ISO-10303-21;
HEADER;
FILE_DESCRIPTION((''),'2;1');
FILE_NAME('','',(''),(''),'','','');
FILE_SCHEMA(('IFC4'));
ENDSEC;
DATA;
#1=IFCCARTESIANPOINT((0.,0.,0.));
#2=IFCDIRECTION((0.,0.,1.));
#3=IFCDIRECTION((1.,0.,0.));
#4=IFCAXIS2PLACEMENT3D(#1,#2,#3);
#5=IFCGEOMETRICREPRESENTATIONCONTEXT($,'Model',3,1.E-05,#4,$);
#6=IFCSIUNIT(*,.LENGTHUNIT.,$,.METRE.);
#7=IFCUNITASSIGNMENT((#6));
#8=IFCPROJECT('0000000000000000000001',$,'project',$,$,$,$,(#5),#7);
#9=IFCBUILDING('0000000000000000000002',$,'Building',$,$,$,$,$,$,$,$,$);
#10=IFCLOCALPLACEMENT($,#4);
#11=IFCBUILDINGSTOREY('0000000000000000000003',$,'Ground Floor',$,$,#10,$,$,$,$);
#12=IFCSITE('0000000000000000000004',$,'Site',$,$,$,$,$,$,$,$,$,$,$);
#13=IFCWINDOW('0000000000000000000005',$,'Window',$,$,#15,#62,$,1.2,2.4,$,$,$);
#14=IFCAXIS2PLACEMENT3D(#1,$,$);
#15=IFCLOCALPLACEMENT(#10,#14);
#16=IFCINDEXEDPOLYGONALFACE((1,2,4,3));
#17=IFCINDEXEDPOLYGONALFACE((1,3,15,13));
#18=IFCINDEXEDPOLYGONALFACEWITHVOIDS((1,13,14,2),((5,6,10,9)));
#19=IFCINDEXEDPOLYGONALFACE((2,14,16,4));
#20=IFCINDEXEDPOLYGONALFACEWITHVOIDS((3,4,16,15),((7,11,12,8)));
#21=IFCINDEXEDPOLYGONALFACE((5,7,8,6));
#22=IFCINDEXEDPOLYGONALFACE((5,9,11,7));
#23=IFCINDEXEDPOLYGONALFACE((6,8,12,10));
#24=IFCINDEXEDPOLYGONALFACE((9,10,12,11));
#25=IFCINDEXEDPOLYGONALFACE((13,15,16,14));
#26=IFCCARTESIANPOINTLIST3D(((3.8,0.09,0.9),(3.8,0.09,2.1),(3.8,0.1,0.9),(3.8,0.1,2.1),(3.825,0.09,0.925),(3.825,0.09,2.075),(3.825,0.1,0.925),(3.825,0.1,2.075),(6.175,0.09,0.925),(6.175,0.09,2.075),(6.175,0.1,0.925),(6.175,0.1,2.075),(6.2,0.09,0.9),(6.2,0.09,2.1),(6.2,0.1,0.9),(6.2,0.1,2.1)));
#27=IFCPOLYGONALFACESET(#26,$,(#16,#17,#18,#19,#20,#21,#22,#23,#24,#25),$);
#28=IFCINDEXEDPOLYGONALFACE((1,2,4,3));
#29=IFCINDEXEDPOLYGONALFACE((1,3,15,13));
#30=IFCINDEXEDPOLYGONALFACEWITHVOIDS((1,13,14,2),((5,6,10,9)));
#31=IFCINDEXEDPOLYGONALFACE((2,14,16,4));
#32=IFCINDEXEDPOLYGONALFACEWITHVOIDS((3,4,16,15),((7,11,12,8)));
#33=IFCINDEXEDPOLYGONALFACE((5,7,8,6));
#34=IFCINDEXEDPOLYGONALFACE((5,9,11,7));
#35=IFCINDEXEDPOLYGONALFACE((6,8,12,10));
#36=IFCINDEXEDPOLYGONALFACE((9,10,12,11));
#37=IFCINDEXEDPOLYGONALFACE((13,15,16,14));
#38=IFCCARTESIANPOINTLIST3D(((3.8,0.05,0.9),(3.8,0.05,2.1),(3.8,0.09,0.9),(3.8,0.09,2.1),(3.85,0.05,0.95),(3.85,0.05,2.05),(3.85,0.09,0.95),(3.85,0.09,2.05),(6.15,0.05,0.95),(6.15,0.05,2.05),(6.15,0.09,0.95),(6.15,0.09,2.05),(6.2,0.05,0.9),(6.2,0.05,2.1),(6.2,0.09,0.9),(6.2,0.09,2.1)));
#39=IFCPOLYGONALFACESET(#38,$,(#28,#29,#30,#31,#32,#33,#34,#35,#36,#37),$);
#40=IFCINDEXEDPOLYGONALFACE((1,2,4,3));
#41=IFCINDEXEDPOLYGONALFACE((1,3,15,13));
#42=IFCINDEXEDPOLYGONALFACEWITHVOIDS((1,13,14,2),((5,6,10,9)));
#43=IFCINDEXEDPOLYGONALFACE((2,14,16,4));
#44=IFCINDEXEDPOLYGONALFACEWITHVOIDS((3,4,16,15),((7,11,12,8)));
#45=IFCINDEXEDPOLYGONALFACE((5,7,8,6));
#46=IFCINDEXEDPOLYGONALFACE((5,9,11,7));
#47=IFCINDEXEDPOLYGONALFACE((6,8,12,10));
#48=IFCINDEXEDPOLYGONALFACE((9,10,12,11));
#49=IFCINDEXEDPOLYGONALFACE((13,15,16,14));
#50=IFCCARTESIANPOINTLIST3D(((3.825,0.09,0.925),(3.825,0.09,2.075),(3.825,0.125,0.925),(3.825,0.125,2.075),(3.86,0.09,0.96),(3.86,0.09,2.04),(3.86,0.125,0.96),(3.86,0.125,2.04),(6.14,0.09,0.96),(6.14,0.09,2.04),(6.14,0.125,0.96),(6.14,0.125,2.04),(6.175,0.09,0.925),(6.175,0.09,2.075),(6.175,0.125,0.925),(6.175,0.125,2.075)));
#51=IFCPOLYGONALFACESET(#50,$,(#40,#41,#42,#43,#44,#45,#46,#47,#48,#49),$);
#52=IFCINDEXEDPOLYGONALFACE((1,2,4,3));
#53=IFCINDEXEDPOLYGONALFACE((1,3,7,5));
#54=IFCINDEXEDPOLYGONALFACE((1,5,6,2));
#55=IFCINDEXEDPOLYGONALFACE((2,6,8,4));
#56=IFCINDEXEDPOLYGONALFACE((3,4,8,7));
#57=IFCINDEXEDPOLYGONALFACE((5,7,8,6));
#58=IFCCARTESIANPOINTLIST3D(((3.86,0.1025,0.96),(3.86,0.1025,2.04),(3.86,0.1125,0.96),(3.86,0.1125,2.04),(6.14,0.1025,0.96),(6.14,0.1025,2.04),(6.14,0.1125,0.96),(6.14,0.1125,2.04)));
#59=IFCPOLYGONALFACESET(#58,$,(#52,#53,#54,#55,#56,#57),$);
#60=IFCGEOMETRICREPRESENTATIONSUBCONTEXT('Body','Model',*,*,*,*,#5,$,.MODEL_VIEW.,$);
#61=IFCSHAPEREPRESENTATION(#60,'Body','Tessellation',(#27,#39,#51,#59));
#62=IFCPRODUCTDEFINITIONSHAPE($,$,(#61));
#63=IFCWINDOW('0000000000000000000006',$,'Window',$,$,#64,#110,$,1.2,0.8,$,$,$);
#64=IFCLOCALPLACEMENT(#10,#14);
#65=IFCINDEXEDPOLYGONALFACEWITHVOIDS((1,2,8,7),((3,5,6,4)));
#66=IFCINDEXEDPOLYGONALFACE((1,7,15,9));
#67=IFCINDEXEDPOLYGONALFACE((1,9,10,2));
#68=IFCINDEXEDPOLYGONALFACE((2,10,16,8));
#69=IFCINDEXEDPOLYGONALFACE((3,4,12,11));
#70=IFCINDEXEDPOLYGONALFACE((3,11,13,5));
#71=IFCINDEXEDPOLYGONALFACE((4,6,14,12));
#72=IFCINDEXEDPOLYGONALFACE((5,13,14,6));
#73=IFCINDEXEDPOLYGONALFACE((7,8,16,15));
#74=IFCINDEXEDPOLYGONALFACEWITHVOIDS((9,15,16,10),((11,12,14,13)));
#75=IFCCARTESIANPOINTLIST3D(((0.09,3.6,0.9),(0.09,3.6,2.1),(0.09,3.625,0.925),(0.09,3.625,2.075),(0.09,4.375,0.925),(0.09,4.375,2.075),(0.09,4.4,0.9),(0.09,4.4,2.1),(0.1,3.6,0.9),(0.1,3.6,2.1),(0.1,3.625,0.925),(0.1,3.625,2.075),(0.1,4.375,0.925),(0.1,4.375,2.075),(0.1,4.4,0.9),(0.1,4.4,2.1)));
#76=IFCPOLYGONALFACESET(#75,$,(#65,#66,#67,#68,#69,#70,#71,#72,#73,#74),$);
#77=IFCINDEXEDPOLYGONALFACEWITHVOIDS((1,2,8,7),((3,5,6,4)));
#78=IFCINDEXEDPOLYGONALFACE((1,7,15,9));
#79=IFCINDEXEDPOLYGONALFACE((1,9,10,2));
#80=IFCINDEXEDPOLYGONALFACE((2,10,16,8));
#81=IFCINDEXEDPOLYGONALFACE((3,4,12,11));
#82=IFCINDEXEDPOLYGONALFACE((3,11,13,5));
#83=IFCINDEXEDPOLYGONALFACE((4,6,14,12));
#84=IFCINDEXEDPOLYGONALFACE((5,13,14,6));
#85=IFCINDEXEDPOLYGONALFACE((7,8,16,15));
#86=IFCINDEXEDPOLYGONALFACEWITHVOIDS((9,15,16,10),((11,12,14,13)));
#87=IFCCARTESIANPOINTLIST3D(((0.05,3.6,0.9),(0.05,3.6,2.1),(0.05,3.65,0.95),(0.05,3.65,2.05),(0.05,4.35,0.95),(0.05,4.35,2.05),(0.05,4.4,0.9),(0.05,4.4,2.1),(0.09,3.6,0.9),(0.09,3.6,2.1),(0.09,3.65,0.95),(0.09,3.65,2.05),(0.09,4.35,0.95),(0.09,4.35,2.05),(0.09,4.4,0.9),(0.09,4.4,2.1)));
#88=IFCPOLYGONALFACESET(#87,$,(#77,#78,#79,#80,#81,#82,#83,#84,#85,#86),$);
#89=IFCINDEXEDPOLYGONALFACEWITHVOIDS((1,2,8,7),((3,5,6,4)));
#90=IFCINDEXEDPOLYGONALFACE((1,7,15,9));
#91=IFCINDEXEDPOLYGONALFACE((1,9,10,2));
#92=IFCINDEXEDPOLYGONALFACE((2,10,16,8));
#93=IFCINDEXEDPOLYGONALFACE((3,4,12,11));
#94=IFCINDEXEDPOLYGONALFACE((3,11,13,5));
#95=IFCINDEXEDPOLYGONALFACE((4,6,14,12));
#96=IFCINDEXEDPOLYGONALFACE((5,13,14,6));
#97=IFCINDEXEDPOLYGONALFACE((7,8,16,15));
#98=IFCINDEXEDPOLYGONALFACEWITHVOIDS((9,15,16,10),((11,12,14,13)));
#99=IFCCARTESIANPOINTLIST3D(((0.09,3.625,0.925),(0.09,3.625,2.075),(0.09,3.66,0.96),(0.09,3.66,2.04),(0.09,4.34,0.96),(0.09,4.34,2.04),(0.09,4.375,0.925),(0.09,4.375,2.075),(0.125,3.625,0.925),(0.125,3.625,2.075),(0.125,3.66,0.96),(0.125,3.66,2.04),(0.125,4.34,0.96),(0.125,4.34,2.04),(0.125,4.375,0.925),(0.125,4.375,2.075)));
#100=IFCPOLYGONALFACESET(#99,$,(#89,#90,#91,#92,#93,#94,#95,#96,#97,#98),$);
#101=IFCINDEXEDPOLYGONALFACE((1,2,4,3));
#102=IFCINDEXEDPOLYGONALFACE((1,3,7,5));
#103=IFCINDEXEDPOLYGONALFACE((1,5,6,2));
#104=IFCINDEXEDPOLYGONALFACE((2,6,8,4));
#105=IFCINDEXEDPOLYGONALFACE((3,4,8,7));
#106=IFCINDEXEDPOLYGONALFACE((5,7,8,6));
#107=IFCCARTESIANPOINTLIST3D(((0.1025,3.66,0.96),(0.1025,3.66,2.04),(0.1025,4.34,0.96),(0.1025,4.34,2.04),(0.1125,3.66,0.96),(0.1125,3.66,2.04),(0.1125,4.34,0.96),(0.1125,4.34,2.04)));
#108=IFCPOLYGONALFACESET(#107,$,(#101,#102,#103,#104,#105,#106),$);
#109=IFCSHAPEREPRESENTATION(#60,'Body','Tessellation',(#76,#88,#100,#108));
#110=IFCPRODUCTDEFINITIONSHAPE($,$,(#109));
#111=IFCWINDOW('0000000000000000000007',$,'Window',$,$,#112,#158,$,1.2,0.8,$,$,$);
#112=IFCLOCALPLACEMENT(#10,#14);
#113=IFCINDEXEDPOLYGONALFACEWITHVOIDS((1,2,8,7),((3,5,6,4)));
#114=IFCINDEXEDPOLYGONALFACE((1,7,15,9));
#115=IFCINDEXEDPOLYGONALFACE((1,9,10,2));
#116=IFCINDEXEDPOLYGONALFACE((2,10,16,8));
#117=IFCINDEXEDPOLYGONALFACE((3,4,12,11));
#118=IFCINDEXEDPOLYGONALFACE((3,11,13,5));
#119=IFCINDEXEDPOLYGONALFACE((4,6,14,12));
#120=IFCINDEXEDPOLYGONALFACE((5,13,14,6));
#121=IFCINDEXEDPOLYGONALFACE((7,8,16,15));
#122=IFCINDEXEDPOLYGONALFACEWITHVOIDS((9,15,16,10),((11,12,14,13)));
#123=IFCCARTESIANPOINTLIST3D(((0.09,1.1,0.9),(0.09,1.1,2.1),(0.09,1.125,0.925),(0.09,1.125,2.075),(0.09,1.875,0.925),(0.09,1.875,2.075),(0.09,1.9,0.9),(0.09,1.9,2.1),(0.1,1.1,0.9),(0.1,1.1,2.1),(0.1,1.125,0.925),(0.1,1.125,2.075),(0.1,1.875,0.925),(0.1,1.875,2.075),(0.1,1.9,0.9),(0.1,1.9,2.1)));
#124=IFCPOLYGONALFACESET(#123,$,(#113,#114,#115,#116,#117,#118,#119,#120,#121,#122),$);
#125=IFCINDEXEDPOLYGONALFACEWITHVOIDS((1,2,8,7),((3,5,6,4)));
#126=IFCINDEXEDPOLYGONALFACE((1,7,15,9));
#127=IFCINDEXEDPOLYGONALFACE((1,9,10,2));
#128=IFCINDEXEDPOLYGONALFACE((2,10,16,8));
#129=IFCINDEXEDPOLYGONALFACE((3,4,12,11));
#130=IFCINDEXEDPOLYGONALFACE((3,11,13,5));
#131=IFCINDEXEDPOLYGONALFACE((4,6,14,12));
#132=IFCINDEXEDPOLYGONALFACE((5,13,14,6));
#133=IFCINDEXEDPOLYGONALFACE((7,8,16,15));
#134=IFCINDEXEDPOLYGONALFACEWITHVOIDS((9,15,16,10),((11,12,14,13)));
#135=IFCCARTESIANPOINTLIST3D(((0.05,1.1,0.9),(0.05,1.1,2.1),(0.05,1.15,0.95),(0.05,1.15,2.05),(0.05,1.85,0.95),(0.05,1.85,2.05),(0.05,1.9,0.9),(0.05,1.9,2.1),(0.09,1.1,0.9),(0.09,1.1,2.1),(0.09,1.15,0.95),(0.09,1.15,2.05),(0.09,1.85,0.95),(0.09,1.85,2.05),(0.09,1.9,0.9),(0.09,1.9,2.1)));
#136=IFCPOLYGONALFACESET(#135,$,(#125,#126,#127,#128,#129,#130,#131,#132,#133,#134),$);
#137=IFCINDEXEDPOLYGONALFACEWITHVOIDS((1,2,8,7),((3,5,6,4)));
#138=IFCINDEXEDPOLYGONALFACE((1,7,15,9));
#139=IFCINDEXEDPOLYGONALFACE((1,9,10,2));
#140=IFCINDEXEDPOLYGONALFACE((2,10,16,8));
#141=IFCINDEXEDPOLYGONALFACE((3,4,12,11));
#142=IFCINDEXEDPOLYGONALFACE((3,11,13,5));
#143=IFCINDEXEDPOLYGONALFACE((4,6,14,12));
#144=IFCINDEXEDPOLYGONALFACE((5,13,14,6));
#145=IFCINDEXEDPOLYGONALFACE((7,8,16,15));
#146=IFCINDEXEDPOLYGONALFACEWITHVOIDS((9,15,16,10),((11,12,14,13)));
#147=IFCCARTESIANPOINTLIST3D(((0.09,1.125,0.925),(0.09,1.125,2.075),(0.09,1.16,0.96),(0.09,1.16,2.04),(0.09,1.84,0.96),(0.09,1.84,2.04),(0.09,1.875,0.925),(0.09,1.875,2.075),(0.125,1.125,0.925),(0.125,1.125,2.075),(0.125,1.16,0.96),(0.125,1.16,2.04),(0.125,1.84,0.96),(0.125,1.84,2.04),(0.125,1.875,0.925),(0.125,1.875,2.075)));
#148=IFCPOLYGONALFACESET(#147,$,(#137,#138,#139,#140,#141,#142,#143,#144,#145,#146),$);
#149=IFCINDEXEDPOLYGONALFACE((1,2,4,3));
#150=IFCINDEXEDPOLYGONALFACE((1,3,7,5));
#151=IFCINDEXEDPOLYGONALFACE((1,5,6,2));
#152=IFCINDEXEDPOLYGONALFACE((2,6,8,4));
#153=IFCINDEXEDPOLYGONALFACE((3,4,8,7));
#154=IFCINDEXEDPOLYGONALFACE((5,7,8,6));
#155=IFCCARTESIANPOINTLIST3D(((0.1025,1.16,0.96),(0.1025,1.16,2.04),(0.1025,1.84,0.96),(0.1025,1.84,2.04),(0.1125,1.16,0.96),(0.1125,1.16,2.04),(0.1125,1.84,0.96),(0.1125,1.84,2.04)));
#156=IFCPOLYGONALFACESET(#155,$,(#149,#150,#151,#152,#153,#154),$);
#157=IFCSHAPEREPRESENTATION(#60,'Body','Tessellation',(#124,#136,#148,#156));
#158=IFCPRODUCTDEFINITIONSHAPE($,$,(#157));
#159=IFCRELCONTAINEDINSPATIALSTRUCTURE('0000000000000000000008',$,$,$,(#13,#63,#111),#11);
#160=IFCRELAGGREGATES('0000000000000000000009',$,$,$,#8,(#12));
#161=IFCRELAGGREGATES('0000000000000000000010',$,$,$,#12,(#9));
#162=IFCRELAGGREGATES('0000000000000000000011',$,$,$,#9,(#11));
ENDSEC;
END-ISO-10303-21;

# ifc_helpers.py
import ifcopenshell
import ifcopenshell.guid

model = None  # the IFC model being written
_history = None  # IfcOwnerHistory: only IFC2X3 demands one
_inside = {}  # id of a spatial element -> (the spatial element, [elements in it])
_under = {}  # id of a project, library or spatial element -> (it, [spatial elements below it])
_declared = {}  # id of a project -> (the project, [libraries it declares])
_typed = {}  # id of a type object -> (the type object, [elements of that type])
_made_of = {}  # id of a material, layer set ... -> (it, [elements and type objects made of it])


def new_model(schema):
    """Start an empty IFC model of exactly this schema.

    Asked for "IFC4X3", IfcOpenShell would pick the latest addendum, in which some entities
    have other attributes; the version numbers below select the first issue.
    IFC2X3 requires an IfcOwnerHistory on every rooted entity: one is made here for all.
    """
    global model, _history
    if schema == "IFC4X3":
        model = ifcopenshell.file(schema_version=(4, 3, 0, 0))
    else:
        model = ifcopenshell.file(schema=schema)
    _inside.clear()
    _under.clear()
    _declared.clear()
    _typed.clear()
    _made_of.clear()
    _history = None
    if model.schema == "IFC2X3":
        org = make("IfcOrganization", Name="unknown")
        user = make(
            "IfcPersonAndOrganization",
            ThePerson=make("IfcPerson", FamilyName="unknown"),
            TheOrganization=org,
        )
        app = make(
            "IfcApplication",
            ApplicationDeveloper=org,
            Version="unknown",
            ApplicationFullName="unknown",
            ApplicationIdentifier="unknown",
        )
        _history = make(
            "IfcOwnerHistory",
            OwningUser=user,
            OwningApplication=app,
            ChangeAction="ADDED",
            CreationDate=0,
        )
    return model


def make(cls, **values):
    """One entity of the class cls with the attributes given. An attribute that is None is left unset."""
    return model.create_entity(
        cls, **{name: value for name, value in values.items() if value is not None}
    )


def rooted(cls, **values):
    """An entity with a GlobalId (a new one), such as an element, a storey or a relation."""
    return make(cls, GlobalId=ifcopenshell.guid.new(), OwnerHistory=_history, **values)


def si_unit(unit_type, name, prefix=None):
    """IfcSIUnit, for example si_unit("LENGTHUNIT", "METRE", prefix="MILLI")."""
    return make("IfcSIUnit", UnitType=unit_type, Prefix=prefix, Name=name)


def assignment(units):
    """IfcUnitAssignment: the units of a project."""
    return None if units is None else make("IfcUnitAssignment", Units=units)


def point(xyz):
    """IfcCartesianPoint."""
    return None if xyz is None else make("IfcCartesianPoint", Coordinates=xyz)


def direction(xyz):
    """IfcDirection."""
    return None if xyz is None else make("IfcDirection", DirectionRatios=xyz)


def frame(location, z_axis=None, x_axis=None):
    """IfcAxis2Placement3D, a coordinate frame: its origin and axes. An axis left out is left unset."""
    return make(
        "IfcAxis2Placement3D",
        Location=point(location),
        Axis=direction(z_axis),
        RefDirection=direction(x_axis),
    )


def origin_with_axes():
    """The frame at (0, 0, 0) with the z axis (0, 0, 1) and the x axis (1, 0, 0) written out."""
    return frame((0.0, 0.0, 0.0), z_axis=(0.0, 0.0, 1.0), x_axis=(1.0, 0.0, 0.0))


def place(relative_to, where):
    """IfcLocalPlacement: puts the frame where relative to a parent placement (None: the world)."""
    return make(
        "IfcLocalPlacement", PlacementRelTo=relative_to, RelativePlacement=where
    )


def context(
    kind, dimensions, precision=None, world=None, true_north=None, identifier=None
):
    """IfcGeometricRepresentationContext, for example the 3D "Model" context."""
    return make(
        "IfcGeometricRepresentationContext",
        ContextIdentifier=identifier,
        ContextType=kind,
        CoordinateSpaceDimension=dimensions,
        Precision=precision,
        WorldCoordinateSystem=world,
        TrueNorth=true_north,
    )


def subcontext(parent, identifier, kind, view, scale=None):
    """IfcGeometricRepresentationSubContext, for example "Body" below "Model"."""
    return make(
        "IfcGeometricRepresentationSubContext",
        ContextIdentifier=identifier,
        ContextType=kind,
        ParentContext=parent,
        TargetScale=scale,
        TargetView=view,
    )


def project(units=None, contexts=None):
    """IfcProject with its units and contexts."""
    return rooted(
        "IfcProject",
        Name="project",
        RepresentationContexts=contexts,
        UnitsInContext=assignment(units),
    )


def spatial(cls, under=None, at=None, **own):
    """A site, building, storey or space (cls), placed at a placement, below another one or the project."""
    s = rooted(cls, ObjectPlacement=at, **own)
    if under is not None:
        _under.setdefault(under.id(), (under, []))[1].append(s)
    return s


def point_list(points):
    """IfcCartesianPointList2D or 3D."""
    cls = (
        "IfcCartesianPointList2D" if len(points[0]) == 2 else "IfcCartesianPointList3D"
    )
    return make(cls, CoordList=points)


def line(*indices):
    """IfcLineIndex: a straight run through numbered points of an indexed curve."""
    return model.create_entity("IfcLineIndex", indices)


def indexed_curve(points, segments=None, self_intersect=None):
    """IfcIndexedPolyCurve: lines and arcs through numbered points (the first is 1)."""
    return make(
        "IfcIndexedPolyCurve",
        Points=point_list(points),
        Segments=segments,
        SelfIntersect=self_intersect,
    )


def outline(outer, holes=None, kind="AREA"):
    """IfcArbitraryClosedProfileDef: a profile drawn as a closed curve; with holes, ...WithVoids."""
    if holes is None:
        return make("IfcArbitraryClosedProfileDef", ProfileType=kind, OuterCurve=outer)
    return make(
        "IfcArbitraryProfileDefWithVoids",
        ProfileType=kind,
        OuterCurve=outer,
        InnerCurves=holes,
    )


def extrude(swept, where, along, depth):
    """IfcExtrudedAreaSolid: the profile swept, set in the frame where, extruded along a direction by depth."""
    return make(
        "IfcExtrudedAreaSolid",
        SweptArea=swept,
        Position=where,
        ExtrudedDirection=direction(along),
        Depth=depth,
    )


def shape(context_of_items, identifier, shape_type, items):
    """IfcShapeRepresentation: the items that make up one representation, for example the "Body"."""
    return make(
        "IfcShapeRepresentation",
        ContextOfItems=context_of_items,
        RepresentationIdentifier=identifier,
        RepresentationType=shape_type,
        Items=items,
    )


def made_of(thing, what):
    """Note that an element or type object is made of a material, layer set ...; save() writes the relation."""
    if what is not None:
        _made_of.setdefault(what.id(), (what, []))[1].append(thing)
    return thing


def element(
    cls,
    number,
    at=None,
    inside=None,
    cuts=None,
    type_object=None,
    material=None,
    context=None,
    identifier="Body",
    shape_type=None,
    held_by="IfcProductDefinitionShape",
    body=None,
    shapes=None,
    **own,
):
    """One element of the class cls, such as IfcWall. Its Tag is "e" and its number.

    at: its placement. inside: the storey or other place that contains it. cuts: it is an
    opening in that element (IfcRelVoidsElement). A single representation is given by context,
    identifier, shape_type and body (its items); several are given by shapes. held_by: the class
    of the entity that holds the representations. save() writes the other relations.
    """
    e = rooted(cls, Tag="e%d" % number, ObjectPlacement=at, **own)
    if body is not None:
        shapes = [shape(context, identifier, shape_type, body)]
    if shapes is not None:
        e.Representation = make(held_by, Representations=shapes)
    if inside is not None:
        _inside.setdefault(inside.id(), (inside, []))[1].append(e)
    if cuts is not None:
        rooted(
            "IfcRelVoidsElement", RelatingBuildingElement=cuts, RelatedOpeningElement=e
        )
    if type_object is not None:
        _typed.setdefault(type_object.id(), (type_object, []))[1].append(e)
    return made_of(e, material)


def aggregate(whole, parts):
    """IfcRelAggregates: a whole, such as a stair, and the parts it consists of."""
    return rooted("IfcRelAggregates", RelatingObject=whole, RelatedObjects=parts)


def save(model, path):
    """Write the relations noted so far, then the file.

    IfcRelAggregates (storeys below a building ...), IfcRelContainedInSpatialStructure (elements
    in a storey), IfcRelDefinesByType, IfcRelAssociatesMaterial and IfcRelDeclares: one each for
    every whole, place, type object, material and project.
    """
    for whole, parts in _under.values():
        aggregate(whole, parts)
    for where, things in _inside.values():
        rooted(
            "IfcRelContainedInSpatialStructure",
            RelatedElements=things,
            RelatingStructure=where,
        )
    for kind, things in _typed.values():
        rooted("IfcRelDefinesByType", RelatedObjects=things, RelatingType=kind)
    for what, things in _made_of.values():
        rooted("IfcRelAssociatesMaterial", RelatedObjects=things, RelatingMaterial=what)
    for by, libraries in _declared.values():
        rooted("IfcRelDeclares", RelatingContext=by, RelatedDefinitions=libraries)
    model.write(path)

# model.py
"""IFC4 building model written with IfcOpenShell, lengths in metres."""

from ifc_helpers import new_model, si_unit, frame, origin_with_axes, place, context, subcontext, project, spatial, line, indexed_curve, outline, extrude, element, save


model = new_model("IFC4")

# Units and contexts
model_context = context("Model", 3, precision=1e-05, world=origin_with_axes())
body_context = subcontext(model_context, "Body", "Model", "MODEL_VIEW")
ifc_project = project(units=[si_unit("LENGTHUNIT", "METRE")], contexts=[model_context])

# Site, building, storey
site = spatial("IfcSite", under=ifc_project, Name="Site")
building = spatial("IfcBuilding", under=site, Name="Building")
storey_placement = place(None, origin_with_axes())
storey = spatial("IfcBuildingStorey", under=building, at=storey_placement, Name="Ground Floor")

# Windows
window_placement = place(storey_placement, frame((3.8, 0.0, 0.9), z_axis=(0.0, 0.0, 1.0), x_axis=(1.0, 0.0, 0.0)))
element("IfcWindow", 1, at=window_placement, inside=storey, Name="Window", OverallHeight=1.2, OverallWidth=2.4, context=body_context, shape_type="SweptSolid", body=[
    extrude(outline(indexed_curve([(0.0, 0.0), (2.4, 0.0), (2.4, 1.2), (0.0, 1.2)], segments=[line(1, 2, 3, 4, 1)]), holes=[indexed_curve([(0.025, 0.025), (2.375, 0.025), (2.375, 1.175), (0.025, 1.175)], segments=[line(1, 2, 3, 4, 1)])]), frame((0.0, 0.09, 0.0), z_axis=(0.0, -1.0, 0.0), x_axis=(1.0, 0.0, 0.0)), (0.0, 0.0, -1.0), 0.01),
    extrude(outline(indexed_curve([(0.0, 0.0), (2.4, 0.0), (2.4, 1.2), (0.0, 1.2)], segments=[line(1, 2, 3, 4, 1)]), holes=[indexed_curve([(0.05, 0.05), (2.35, 0.05), (2.35, 1.15), (0.05, 1.15)], segments=[line(1, 2, 3, 4, 1)])]), frame((0.0, 0.05, 0.0), z_axis=(0.0, -1.0, 0.0), x_axis=(1.0, 0.0, 0.0)), (0.0, 0.0, -1.0), 0.04),
    extrude(outline(indexed_curve([(0.0, 0.0), (2.35, 0.0), (2.35, 1.15), (0.0, 1.15)], segments=[line(1, 2, 3, 4, 1)]), holes=[indexed_curve([(0.035, 0.035), (2.315, 0.035), (2.315, 1.115), (0.035, 1.115)], segments=[line(1, 2, 3, 4, 1)])]), frame((0.025, 0.09, 0.025), z_axis=(0.0, -1.0, 0.0), x_axis=(1.0, 0.0, 0.0)), (0.0, 0.0, -1.0), 0.035),
    extrude(outline(indexed_curve([(0.035, 0.035), (2.315, 0.035), (2.315, 1.115), (0.035, 1.115)], segments=[line(1, 2, 3, 4, 1)])), frame((0.025, 0.1025, 0.025), z_axis=(0.0, -1.0, 0.0), x_axis=(1.0, 0.0, 0.0)), (0.0, 0.0, -1.0), 0.01),
])
for number, where, z_axis, x_axis, name in (
    (2, (0.0, 4.4, 0.9), (0.0, 0.0, 1.0), (0.0, -1.0, 0.0), "Window"),
    (3, (0.0, 1.9, 0.9), (0.0, 0.0, 1.0), (0.0, -1.0, 0.0), "Window"),
):
    element("IfcWindow", number, at=place(storey_placement, frame(where, z_axis=z_axis, x_axis=x_axis)), inside=storey, Name=name, OverallHeight=1.2, OverallWidth=0.8, context=body_context, shape_type="SweptSolid", body=[
        extrude(outline(indexed_curve([(0.0, 0.0), (0.8, 0.0), (0.8, 1.2), (0.0, 1.2)], segments=[line(1, 2, 3, 4, 1)]), holes=[indexed_curve([(0.025, 0.025), (0.775, 0.025), (0.775, 1.175), (0.025, 1.175)], segments=[line(1, 2, 3, 4, 1)])]), frame((0.0, 0.09, 0.0), z_axis=(0.0, -1.0, 0.0), x_axis=(1.0, 0.0, 0.0)), (0.0, 0.0, -1.0), 0.01),
        extrude(outline(indexed_curve([(0.0, 0.0), (0.8, 0.0), (0.8, 1.2), (0.0, 1.2)], segments=[line(1, 2, 3, 4, 1)]), holes=[indexed_curve([(0.05, 0.05), (0.75, 0.05), (0.75, 1.15), (0.05, 1.15)], segments=[line(1, 2, 3, 4, 1)])]), frame((0.0, 0.05, 0.0), z_axis=(0.0, -1.0, 0.0), x_axis=(1.0, 0.0, 0.0)), (0.0, 0.0, -1.0), 0.04),
        extrude(outline(indexed_curve([(0.0, 0.0), (0.75, 0.0), (0.75, 1.15), (0.0, 1.15)], segments=[line(1, 2, 3, 4, 1)]), holes=[indexed_curve([(0.035, 0.035), (0.715, 0.035), (0.715, 1.115), (0.035, 1.115)], segments=[line(1, 2, 3, 4, 1)])]), frame((0.025, 0.09, 0.025), z_axis=(0.0, -1.0, 0.0), x_axis=(1.0, 0.0, 0.0)), (0.0, 0.0, -1.0), 0.035),
        extrude(outline(indexed_curve([(0.035, 0.035), (0.715, 0.035), (0.715, 1.115), (0.035, 1.115)], segments=[line(1, 2, 3, 4, 1)])), frame((0.025, 0.1025, 0.025), z_axis=(0.0, -1.0, 0.0), x_axis=(1.0, 0.0, 0.0)), (0.0, 0.0, -1.0), 0.01),
    ])

save(model, "model.ifc")
